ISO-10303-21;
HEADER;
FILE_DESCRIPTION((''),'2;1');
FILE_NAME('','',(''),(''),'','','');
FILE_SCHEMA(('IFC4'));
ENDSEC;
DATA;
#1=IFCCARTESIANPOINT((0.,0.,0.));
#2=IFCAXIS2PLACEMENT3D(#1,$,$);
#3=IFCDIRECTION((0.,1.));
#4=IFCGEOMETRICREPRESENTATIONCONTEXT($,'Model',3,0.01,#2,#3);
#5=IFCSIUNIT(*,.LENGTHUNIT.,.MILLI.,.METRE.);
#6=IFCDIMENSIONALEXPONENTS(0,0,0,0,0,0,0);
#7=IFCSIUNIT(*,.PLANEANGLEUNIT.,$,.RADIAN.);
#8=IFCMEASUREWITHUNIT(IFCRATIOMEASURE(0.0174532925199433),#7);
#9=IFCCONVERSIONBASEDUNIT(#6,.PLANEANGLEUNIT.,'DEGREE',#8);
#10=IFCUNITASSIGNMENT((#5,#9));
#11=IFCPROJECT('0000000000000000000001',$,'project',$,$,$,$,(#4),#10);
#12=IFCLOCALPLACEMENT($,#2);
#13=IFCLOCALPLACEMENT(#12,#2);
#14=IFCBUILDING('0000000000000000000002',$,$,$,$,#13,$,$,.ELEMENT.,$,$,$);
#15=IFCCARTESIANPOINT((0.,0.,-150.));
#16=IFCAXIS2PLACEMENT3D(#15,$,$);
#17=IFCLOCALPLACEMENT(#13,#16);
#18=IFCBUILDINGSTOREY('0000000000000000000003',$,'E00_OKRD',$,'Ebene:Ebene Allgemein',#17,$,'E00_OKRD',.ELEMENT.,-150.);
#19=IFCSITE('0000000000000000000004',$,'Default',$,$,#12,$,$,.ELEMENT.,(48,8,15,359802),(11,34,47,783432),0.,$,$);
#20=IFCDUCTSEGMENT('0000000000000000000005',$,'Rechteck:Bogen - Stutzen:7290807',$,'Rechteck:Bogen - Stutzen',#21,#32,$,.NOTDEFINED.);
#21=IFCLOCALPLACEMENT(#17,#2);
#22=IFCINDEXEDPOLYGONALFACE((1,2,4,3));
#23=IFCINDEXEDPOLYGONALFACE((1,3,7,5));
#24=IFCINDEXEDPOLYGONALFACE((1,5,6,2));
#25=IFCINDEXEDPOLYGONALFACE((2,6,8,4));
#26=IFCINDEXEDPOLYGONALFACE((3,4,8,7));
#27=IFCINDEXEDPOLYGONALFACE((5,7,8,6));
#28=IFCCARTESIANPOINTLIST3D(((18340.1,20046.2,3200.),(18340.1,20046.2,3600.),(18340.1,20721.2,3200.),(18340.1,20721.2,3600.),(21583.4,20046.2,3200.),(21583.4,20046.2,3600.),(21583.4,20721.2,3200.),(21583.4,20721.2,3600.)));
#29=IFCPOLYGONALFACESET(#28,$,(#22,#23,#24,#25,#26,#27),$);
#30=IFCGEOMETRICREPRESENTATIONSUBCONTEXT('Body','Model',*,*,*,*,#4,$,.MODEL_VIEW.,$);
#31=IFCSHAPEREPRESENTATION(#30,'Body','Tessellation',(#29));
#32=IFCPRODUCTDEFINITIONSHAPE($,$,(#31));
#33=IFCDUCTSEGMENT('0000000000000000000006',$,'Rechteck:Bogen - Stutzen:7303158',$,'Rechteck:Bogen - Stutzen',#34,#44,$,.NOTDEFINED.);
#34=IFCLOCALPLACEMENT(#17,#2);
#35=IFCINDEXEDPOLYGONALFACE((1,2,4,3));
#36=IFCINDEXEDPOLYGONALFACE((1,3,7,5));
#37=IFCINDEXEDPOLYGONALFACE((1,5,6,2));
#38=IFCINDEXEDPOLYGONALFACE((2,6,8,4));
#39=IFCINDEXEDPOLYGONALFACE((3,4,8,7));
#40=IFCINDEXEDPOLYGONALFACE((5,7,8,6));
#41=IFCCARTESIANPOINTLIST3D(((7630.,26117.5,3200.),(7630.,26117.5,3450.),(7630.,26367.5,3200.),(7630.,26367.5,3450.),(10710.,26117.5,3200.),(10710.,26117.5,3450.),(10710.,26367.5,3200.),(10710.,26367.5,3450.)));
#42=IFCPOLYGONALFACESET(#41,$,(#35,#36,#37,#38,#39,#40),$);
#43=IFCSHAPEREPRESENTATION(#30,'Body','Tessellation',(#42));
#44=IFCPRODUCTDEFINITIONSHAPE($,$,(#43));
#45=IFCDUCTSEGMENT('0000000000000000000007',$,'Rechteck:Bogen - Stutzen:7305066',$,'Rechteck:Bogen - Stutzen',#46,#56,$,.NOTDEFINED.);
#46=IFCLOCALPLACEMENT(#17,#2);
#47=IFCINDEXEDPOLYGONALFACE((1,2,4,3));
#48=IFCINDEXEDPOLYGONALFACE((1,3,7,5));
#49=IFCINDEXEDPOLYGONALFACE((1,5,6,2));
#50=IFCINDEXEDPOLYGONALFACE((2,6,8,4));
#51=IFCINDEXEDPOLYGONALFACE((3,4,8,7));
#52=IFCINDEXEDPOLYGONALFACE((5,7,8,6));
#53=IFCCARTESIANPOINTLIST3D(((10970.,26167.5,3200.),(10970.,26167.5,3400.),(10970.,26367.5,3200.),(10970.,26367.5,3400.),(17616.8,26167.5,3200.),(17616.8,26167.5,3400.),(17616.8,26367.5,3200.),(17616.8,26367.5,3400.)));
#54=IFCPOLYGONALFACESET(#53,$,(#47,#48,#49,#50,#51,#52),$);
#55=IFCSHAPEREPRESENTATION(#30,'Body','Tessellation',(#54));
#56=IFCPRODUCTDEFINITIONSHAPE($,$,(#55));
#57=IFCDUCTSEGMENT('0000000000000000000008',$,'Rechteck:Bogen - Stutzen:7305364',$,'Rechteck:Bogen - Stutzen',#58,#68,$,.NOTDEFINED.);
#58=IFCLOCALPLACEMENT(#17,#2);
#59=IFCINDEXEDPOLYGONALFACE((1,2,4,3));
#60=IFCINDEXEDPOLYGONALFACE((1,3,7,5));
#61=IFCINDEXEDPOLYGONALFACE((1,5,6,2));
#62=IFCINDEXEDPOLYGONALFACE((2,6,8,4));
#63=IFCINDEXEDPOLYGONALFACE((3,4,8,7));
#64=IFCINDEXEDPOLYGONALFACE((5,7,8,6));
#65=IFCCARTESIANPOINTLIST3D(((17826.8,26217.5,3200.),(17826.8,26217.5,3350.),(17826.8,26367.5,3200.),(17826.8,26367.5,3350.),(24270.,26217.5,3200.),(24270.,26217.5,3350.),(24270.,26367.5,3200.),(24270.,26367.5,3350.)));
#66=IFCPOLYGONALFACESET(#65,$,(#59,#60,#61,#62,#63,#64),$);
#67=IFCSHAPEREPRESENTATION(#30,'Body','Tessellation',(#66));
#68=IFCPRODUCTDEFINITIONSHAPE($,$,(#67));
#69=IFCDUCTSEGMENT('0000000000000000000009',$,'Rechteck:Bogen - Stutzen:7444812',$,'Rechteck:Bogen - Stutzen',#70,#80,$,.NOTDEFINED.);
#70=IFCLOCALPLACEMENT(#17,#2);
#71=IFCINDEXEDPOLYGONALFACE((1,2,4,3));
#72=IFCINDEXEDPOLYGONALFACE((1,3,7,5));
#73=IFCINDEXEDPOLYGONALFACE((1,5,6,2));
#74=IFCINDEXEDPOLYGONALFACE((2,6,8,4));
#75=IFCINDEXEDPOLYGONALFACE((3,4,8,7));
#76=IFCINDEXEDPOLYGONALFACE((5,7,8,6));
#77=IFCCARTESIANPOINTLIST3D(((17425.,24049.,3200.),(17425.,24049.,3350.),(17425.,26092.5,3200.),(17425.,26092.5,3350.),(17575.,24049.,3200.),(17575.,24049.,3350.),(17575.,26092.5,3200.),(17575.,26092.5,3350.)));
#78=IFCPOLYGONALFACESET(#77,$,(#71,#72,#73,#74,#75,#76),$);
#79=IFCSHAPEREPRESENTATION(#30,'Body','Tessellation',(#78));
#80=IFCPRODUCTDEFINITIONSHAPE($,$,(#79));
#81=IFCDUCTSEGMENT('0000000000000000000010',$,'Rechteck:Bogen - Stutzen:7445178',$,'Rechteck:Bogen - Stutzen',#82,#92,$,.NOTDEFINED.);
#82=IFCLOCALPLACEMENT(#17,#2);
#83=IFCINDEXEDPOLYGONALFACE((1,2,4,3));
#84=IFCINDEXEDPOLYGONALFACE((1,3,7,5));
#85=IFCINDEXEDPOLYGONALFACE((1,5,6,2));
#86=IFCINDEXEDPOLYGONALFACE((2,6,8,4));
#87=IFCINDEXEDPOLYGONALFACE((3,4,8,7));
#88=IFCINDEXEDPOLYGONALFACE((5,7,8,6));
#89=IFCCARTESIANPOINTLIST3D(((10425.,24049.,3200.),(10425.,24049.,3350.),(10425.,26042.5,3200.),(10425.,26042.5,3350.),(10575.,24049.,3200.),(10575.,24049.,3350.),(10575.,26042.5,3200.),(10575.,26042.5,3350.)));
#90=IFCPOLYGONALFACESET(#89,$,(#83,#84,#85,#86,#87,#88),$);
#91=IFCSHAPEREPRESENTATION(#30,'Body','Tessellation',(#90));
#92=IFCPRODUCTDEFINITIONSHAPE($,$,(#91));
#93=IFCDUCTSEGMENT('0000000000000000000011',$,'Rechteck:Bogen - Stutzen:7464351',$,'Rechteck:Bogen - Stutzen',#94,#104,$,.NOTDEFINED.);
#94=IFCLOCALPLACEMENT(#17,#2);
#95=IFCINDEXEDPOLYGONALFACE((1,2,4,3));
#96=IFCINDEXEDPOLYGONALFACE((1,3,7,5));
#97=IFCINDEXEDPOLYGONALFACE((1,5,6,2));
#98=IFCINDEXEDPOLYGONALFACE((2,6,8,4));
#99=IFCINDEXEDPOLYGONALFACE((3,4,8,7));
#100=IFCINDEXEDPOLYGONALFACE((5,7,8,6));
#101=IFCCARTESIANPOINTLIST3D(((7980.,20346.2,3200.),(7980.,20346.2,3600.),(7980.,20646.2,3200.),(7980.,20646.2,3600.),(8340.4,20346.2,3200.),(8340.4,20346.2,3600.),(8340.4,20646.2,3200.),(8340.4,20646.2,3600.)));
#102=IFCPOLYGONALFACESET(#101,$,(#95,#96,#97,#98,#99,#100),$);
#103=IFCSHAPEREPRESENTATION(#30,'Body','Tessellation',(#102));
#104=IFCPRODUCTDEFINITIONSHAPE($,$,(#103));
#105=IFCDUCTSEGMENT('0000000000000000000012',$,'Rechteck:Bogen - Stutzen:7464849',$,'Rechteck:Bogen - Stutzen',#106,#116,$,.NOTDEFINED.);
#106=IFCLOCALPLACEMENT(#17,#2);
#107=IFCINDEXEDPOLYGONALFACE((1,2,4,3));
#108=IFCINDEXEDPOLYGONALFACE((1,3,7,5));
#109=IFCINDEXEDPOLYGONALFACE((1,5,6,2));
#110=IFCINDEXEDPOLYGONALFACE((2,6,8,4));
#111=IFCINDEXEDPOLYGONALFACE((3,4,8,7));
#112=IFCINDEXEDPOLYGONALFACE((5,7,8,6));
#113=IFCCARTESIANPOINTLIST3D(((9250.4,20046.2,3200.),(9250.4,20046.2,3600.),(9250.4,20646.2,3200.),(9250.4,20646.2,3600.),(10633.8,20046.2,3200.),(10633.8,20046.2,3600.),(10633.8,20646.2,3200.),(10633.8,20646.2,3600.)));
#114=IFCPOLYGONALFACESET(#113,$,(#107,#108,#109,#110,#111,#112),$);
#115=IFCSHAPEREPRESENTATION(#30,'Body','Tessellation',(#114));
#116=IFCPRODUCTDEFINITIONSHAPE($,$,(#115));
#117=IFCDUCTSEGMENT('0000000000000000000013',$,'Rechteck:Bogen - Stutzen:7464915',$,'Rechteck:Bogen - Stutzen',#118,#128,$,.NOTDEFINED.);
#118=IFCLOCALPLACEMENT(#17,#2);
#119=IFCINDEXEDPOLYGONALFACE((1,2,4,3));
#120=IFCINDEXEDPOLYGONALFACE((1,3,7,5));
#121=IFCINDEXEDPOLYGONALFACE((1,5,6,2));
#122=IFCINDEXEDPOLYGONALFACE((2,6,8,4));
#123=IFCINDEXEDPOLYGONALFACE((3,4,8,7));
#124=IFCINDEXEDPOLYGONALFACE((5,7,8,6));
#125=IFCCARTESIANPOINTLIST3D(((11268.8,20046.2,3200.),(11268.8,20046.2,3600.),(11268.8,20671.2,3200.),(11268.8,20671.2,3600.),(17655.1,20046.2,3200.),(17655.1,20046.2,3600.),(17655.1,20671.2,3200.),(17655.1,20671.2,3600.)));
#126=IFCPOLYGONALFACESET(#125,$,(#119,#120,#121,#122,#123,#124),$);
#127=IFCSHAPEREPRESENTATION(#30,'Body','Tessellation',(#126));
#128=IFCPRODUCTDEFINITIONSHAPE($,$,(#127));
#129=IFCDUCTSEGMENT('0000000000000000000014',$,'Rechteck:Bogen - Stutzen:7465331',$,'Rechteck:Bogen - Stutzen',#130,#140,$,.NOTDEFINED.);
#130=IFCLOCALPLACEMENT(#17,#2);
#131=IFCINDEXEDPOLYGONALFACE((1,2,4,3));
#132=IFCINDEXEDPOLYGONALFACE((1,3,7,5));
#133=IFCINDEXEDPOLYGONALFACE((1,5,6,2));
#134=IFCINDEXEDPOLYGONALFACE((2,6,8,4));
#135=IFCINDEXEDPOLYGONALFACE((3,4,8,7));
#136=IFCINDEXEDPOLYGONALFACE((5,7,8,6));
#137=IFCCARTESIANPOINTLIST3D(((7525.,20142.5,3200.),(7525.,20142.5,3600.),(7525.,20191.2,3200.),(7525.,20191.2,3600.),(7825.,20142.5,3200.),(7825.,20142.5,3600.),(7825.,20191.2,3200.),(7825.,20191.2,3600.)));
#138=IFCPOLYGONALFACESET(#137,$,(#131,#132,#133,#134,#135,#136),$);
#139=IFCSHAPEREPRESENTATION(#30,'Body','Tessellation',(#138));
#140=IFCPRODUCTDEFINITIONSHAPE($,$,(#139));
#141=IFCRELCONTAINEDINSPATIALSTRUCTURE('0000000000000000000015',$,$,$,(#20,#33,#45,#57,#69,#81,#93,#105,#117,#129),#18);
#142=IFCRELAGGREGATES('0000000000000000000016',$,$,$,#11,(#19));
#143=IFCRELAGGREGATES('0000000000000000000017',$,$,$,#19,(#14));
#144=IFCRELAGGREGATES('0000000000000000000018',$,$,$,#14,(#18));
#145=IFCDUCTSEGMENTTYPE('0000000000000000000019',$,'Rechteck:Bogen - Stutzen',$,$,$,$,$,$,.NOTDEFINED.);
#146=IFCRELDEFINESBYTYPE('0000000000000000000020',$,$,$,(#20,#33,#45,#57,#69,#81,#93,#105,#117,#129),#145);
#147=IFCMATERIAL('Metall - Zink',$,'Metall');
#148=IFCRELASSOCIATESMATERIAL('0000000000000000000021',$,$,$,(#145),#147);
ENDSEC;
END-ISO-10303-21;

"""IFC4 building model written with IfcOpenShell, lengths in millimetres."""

from ifc_helpers import new_model, entity, si_unit, converted_unit, direction, frame, frame_2d, origin, place, context, subcontext, project, spatial, rectangle, extrude, material, type_object, element, save


model = new_model("IFC4")

# Units and contexts
model_context = context("Model", 3, precision=0.01, world=origin(), true_north=direction((0.0, 1.0)))
body_context = subcontext(model_context, "Body", "Model", "MODEL_VIEW")
ifc_project = project(units=[si_unit("LENGTHUNIT", "METRE", prefix="MILLI"), converted_unit("PLANEANGLEUNIT", "DEGREE", entity("IfcRatioMeasure", 0.0174532925199433), si_unit("PLANEANGLEUNIT", "RADIAN"), dimensions=[0, 0, 0, 0, 0, 0, 0])], contexts=[model_context])

# Site, building, storey
site_placement = place(None, origin())
site = spatial("IfcSite", under=ifc_project, at=site_placement, Name="Default", CompositionType="ELEMENT", RefLatitude=(48, 8, 15, 359802), RefLongitude=(11, 34, 47, 783432), RefElevation=0.0)
building_placement = place(site_placement, origin())
building = spatial("IfcBuilding", under=site, at=building_placement, CompositionType="ELEMENT")
storey_placement = place(building_placement, frame((0.0, 0.0, -150.0)))
storey = spatial("IfcBuildingStorey", under=building, at=storey_placement, Name="E00_OKRD", ObjectType="Ebene:Ebene Allgemein", LongName="E00_OKRD", CompositionType="ELEMENT", Elevation=-150.0)

# Duct segments
ifc_material_1 = material(Name="Metall - Zink", Category="Metall")
duct_segment_type_1 = type_object("IfcDuctSegmentType", Name="Rechteck:Bogen - Stutzen", PredefinedType="NOTDEFINED", material=ifc_material_1)
duct_segment_1_placement = place(storey_placement, frame((18340.1, 20046.2, 3200.0)))
element("IfcDuctSegment", 1, at=duct_segment_1_placement, inside=storey, type_object=duct_segment_type_1, Name="Rechteck:Bogen - Stutzen:7290807", ObjectType="Rechteck:Bogen - Stutzen", PredefinedType="NOTDEFINED", context=body_context, shape_type="SweptSolid", body=[
    extrude(rectangle(XDim=3243.2, YDim=675.0, at=frame_2d((0.0, 0.0), x_axis=(1.0, 0.0))), frame((1621.6, 337.5, 0.0)), (0.0, 0.0, 1.0), 400.0),
])
duct_segment_2_placement = place(storey_placement, frame((7630.0, 26117.5, 3200.0)))
element("IfcDuctSegment", 2, at=duct_segment_2_placement, inside=storey, type_object=duct_segment_type_1, Name="Rechteck:Bogen - Stutzen:7303158", ObjectType="Rechteck:Bogen - Stutzen", PredefinedType="NOTDEFINED", context=body_context, shape_type="SweptSolid", body=[
    extrude(rectangle(XDim=3080.0, YDim=250.0, at=frame_2d((0.0, 0.0), x_axis=(1.0, 0.0))), frame((1540.0, 125.0, 0.0)), (0.0, 0.0, 1.0), 250.0),
])
duct_segment_3_placement = place(storey_placement, frame((10970.0, 26167.5, 3200.0)))
element("IfcDuctSegment", 3, at=duct_segment_3_placement, inside=storey, type_object=duct_segment_type_1, Name="Rechteck:Bogen - Stutzen:7305066", ObjectType="Rechteck:Bogen - Stutzen", PredefinedType="NOTDEFINED", context=body_context, shape_type="SweptSolid", body=[
    extrude(rectangle(XDim=6646.8, YDim=200.0, at=frame_2d((0.0, 0.0), x_axis=(1.0, 0.0))), frame((3323.4, 100.0, 0.0), z_axis=(0.000004, 0.0, 1.0), x_axis=(-1.0, 0.0, 0.000004)), (0.0, 0.0, 1.0), 200.0),
])
duct_segment_4_placement = place(storey_placement, frame((17826.8, 26217.5, 3200.0)))
element("IfcDuctSegment", 4, at=duct_segment_4_placement, inside=storey, type_object=duct_segment_type_1, Name="Rechteck:Bogen - Stutzen:7305364", ObjectType="Rechteck:Bogen - Stutzen", PredefinedType="NOTDEFINED", context=body_context, shape_type="SweptSolid", body=[
    extrude(rectangle(XDim=6443.2, YDim=150.0, at=frame_2d((0.0, 0.0), x_axis=(1.0, 0.0))), frame((3221.6, 75.0, 0.0), z_axis=(0.000004, 0.0, 1.0), x_axis=(-1.0, 0.0, 0.000004)), (0.0, 0.0, 1.0), 150.0),
])
duct_segment_5_placement = place(storey_placement, frame((17425.0, 24049.0, 3200.0)))
element("IfcDuctSegment", 5, at=duct_segment_5_placement, inside=storey, type_object=duct_segment_type_1, Name="Rechteck:Bogen - Stutzen:7444812", ObjectType="Rechteck:Bogen - Stutzen", PredefinedType="NOTDEFINED", context=body_context, shape_type="SweptSolid", body=[
    extrude(rectangle(XDim=2043.5, YDim=150.0, at=frame_2d((0.0, 0.0), x_axis=(1.0, 0.0))), frame((75.0, 1021.7, 0.0), z_axis=(0.0, 0.0, 1.0), x_axis=(0.0, -1.0, 0.0)), (0.0, 0.0, 1.0), 150.0),
])
duct_segment_6_placement = place(storey_placement, frame((10425.0, 24049.0, 3200.0)))
element("IfcDuctSegment", 6, at=duct_segment_6_placement, inside=storey, type_object=duct_segment_type_1, Name="Rechteck:Bogen - Stutzen:7445178", ObjectType="Rechteck:Bogen - Stutzen", PredefinedType="NOTDEFINED", context=body_context, shape_type="SweptSolid", body=[
    extrude(rectangle(XDim=1993.5, YDim=150.0, at=frame_2d((0.0, 0.0), x_axis=(1.0, 0.0))), frame((75.0, 996.7, 0.0), z_axis=(0.0, 0.0, 1.0), x_axis=(0.0, -1.0, 0.0)), (0.0, 0.0, 1.0), 150.0),
])
duct_segment_7_placement = place(storey_placement, frame((7980.0, 20346.2, 3200.0)))
element("IfcDuctSegment", 7, at=duct_segment_7_placement, inside=storey, type_object=duct_segment_type_1, Name="Rechteck:Bogen - Stutzen:7464351", ObjectType="Rechteck:Bogen - Stutzen", PredefinedType="NOTDEFINED", context=body_context, shape_type="SweptSolid", body=[
    extrude(rectangle(XDim=360.4, YDim=300.0, at=frame_2d((0.0, 0.0), x_axis=(1.0, 0.0))), frame((180.2, 150.0, 0.0), z_axis=(0.0, 0.0, 1.0), x_axis=(-1.0, 0.0, 0.0)), (0.0, 0.0, 1.0), 400.0),
])
duct_segment_8_placement = place(storey_placement, frame((9250.4, 20046.2, 3200.0)))
element("IfcDuctSegment", 8, at=duct_segment_8_placement, inside=storey, type_object=duct_segment_type_1, Name="Rechteck:Bogen - Stutzen:7464849", ObjectType="Rechteck:Bogen - Stutzen", PredefinedType="NOTDEFINED", context=body_context, shape_type="SweptSolid", body=[
    extrude(rectangle(XDim=1383.5, YDim=600.0, at=frame_2d((0.0, 0.0), x_axis=(1.0, 0.0))), frame((691.7, 300.0, 0.0), z_axis=(0.0, 0.0, 1.0), x_axis=(-1.0, 0.0, 0.0)), (0.0, 0.0, 1.0), 400.0),
])
duct_segment_9_placement = place(storey_placement, frame((11268.8, 20046.2, 3200.0)))
element("IfcDuctSegment", 9, at=duct_segment_9_placement, inside=storey, type_object=duct_segment_type_1, Name="Rechteck:Bogen - Stutzen:7464915", ObjectType="Rechteck:Bogen - Stutzen", PredefinedType="NOTDEFINED", context=body_context, shape_type="SweptSolid", body=[
    extrude(rectangle(XDim=6386.3, YDim=625.0, at=frame_2d((0.0, 0.0), x_axis=(1.0, 0.0))), frame((3193.1, 312.5, 0.0), z_axis=(0.0, 0.0, 1.0), x_axis=(-1.0, 0.0, 0.0)), (0.0, 0.0, 1.0), 400.0),
])
duct_segment_10_placement = place(storey_placement, frame((7525.0, 20142.5, 3200.0)))
element("IfcDuctSegment", 10, at=duct_segment_10_placement, inside=storey, type_object=duct_segment_type_1, Name="Rechteck:Bogen - Stutzen:7465331", ObjectType="Rechteck:Bogen - Stutzen", PredefinedType="NOTDEFINED", context=body_context, shape_type="SweptSolid", body=[
    extrude(rectangle(XDim=48.7, YDim=300.0, at=frame_2d((0.0, 0.0), x_axis=(1.0, 0.0))), frame((150.0, 24.4, 0.0), z_axis=(0.0, 0.0, 1.0), x_axis=(0.0, 1.0, 0.0)), (0.0, 0.0, 1.0), 400.0),
])

save(model, "model.ifc")
